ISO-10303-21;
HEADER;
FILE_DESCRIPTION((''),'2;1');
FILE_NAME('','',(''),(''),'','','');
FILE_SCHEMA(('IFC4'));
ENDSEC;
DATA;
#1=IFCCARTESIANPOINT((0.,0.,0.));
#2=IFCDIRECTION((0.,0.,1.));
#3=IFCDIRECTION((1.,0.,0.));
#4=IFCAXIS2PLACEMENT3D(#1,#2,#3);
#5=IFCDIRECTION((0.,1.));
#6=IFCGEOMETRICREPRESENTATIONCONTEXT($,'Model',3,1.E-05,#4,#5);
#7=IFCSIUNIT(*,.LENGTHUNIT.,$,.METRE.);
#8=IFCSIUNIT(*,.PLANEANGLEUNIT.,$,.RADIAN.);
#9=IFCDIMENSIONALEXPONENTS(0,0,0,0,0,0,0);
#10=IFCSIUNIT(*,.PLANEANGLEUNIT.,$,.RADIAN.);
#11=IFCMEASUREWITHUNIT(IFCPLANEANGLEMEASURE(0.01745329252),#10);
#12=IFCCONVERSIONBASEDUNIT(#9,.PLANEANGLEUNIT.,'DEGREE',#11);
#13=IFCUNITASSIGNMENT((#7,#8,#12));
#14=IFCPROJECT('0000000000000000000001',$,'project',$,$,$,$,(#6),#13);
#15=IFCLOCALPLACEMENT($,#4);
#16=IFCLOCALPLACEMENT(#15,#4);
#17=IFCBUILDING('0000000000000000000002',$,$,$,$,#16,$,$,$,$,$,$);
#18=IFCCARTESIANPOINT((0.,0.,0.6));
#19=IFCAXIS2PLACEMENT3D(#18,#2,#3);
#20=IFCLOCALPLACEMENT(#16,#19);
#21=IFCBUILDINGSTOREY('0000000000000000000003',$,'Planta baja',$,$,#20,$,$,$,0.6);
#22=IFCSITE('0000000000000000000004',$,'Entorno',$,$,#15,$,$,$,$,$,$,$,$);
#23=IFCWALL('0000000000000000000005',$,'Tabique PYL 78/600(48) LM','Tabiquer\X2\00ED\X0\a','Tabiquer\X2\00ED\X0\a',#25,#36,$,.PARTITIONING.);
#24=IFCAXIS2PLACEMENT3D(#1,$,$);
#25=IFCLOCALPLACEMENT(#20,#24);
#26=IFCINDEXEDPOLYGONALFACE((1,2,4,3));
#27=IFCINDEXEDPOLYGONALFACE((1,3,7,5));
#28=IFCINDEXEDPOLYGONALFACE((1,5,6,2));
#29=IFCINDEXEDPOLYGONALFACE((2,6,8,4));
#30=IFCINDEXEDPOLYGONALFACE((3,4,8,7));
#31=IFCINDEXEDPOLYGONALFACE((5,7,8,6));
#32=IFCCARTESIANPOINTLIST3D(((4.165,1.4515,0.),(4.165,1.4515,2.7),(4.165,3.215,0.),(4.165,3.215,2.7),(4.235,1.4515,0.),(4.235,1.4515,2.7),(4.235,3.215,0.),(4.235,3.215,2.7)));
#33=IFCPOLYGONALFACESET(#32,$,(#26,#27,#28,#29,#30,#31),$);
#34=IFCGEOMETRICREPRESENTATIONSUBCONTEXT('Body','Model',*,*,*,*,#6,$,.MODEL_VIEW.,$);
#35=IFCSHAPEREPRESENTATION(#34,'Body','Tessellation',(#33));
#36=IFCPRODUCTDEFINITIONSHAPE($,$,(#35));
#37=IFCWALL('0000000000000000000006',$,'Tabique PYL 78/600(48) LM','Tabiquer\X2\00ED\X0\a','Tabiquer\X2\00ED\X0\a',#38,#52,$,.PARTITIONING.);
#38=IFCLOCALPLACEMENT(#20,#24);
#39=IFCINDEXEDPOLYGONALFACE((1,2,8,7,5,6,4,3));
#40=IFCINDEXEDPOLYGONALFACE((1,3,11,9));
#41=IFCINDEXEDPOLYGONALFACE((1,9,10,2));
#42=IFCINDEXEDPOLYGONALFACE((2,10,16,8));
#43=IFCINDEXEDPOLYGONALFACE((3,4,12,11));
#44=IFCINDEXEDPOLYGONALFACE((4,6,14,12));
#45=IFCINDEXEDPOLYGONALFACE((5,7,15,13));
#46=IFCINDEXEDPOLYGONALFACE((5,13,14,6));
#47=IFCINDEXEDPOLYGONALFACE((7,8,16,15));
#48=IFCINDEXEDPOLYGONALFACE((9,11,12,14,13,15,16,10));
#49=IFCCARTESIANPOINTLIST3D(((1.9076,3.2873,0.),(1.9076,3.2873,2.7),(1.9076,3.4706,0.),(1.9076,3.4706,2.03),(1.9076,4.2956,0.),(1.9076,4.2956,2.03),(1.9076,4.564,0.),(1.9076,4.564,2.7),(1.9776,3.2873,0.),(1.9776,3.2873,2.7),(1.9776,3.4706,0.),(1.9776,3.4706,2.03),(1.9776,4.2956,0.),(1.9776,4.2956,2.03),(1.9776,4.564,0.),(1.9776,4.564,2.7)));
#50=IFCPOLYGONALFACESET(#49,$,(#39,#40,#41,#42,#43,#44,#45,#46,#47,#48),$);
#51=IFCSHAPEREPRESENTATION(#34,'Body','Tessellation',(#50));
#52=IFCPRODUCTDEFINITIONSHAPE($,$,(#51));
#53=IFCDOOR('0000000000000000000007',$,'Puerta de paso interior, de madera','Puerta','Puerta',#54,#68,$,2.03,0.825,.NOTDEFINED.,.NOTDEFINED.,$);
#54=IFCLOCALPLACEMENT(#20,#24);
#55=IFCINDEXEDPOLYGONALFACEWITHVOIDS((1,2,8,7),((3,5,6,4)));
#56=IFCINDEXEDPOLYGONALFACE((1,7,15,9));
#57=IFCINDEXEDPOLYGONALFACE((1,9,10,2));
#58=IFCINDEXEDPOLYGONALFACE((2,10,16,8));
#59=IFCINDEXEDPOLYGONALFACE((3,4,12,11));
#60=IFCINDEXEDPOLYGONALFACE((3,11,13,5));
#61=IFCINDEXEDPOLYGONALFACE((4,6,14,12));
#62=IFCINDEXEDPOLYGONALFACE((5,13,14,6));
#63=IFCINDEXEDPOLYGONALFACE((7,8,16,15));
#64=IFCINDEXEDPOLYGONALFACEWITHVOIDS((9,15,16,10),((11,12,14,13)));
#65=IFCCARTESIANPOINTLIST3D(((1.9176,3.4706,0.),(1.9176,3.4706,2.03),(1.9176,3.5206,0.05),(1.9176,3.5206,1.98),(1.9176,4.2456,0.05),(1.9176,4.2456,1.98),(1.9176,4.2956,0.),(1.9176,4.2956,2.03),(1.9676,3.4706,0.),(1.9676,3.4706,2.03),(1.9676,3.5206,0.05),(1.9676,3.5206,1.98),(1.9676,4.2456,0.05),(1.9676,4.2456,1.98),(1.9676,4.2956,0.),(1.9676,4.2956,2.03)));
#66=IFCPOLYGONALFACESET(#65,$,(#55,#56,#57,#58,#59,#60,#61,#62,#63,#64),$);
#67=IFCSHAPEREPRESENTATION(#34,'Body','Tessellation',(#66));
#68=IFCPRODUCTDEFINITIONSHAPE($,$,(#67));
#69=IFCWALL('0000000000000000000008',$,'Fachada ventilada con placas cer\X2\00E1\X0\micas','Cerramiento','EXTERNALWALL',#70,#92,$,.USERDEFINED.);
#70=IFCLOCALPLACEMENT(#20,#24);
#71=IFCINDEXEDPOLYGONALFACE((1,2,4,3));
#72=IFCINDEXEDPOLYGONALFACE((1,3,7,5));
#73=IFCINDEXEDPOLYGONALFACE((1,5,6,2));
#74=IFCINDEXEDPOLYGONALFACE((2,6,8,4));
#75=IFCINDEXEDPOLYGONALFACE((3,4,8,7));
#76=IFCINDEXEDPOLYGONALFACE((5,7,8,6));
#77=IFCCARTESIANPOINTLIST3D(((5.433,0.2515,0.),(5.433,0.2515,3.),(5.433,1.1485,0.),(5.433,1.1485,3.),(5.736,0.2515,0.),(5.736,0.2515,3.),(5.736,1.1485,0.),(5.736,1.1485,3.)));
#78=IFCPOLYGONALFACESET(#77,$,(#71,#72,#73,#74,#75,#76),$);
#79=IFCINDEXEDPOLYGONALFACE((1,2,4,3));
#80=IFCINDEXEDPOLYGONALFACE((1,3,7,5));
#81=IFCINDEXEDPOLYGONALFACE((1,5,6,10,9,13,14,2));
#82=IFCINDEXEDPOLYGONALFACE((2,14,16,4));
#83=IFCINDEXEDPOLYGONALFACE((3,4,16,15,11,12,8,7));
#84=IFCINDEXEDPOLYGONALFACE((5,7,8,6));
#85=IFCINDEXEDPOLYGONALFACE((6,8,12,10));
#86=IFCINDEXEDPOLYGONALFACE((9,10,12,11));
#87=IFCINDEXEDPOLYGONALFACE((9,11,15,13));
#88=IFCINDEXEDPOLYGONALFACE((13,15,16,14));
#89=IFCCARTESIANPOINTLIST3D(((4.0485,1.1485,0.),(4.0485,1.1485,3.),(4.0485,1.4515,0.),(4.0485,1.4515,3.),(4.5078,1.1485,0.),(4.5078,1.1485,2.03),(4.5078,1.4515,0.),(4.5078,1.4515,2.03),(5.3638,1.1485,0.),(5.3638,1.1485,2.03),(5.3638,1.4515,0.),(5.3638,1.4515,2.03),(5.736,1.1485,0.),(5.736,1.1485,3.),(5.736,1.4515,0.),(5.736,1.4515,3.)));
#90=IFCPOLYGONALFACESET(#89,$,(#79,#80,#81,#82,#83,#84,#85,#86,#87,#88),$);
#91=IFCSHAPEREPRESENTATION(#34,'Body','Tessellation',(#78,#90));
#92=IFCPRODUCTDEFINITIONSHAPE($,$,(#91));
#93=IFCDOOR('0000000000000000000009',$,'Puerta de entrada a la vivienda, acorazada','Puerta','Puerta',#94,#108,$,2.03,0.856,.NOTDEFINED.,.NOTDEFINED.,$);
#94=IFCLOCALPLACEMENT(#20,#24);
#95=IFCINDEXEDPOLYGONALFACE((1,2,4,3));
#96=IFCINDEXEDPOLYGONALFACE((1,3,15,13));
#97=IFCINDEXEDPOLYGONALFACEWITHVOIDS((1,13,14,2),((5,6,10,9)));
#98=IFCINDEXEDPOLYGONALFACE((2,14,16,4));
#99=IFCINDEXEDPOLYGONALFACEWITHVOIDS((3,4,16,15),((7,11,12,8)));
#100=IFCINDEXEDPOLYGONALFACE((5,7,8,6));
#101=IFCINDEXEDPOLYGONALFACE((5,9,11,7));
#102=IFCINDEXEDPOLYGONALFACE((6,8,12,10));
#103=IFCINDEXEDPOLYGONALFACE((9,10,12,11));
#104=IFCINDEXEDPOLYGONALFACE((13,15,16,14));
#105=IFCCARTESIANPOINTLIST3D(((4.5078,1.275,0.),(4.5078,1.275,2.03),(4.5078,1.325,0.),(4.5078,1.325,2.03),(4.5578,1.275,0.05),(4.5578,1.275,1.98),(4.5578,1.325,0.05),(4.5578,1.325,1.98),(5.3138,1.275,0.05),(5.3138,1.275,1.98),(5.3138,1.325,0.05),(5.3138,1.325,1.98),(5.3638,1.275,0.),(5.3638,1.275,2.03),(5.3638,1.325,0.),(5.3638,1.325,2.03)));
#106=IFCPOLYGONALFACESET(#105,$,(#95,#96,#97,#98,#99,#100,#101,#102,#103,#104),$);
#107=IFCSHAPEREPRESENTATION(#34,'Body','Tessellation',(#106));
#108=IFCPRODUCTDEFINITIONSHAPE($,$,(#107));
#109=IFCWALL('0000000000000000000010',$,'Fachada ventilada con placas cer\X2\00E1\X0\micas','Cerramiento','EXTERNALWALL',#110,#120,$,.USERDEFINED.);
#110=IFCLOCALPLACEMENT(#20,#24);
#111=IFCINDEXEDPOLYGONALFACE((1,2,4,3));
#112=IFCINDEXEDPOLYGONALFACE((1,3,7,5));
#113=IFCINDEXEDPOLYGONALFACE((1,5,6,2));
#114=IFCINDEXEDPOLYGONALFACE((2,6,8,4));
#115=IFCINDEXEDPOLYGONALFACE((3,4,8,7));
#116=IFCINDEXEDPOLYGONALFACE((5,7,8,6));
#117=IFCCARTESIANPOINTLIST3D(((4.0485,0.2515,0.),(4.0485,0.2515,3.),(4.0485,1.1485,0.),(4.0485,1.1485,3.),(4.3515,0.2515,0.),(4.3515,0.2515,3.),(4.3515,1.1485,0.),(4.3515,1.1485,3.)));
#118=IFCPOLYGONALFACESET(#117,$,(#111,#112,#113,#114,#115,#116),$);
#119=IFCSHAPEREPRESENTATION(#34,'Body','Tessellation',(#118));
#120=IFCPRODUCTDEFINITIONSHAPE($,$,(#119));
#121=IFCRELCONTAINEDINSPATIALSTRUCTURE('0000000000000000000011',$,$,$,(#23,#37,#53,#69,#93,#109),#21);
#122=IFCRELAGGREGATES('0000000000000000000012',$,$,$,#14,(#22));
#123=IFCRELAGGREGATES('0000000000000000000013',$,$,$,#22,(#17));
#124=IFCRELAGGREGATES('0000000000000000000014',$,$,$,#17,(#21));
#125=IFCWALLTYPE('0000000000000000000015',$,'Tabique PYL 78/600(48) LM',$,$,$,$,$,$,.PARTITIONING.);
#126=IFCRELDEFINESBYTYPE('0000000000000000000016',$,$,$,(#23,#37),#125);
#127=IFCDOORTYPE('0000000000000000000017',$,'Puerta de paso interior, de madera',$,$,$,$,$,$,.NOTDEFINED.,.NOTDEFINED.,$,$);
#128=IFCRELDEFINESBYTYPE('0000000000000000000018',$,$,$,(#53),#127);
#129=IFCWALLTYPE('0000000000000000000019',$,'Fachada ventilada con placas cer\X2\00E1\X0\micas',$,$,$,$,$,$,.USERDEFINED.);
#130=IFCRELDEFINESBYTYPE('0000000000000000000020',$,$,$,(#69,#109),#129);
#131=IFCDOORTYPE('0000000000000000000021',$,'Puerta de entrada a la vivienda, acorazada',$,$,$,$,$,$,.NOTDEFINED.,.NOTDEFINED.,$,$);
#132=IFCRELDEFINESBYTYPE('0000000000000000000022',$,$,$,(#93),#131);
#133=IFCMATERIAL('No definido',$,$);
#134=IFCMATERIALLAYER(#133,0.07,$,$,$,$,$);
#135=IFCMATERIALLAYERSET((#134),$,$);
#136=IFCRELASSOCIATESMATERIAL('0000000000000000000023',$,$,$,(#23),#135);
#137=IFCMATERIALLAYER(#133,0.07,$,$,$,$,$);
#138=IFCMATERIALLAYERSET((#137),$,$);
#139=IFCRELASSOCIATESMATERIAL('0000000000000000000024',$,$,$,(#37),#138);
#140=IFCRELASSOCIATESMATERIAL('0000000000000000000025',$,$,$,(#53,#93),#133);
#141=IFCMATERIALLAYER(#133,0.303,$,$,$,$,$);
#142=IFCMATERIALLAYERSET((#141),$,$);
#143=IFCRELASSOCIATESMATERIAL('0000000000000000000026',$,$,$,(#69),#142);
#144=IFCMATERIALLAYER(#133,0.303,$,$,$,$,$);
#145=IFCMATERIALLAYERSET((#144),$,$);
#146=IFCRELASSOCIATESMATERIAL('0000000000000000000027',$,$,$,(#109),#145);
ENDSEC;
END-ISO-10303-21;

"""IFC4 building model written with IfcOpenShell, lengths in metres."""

from ifc_helpers import new_model, entity, si_unit, converted_unit, direction, frame, origin_with_axes, origin_2d_with_axis, place, context, subcontext, project, spatial, rectangle, hollow_rectangle, extrude, shape, material, layer, layer_set, layer_usage, type_object, element, fill, save


model = new_model("IFC4")

# Units and contexts
model_context = context("Model", 3, precision=1e-05, world=origin_with_axes(), true_north=direction((0.0, 1.0)))
body_context = subcontext(model_context, "Body", "Model", "MODEL_VIEW")
footprint_context = subcontext(model_context, "FootPrint", "Model", "MODEL_VIEW")
ifc_project = project(units=[si_unit("LENGTHUNIT", "METRE"), si_unit("PLANEANGLEUNIT", "RADIAN"), converted_unit("PLANEANGLEUNIT", "DEGREE", entity("IfcPlaneAngleMeasure", 0.01745329252), si_unit("PLANEANGLEUNIT", "RADIAN"), dimensions=[0, 0, 0, 0, 0, 0, 0])], contexts=[model_context])

# Site, building, storey
site_placement = place(None, origin_with_axes())
site = spatial("IfcSite", under=ifc_project, at=site_placement, Name="Entorno")
building_placement = place(site_placement, origin_with_axes())
building = spatial("IfcBuilding", under=site, at=building_placement)
storey_placement = place(building_placement, frame((0.0, 0.0, 0.6), z_axis=(0.0, 0.0, 1.0), x_axis=(1.0, 0.0, 0.0)))
storey = spatial("IfcBuildingStorey", under=building, at=storey_placement, Name="Planta baja", Elevation=0.6)

# Wall
ifc_material_1 = material(Name="No definido")
ifc_layer_1 = layer(ifc_material_1, 0.07)
ifc_layer_set_1 = layer_set([ifc_layer_1])
ifc_layer_usage_1 = layer_usage(ifc_layer_set_1, "AXIS2", "POSITIVE", -0.035)
wall_type_1 = type_object("IfcWallType", Name="Tabique PYL 78/600(48) LM", PredefinedType="PARTITIONING")
wall_1_placement = place(storey_placement, frame((4.2, 1.3, 0.0), z_axis=(0.0, 0.0, 1.0), x_axis=(0.0, 1.0, 0.0)))
cartesian_point_1 = entity("IfcCartesianPoint", [-0.8817, -1.35])
cartesian_point_2 = entity("IfcCartesianPoint", [-0.8817, -1.35])
element("IfcWall", 1, at=wall_1_placement, inside=storey, type_object=wall_type_1, material=ifc_layer_usage_1, Name="Tabique PYL 78/600(48) LM", Description="Tabiquería", ObjectType="Tabiquería", PredefinedType="PARTITIONING", context=body_context, shape_type="SolidModel", body=[
    entity("IfcExtrudedAreaSolidTapered", entity("IfcArbitraryClosedProfileDef", "AREA", None, entity("IfcPolyline", [cartesian_point_1, entity("IfcCartesianPoint", [0.8817, -1.35]), entity("IfcCartesianPoint", [0.8817, 1.35]), entity("IfcCartesianPoint", [-0.8817, 1.35]), cartesian_point_1])), entity("IfcAxis2Placement3D", entity("IfcCartesianPoint", [1.0332, 0.035, 1.35]), entity("IfcDirection", [0.0, -1.0, 0.0]), entity("IfcDirection", [1.0, 0.0, 0.0])), entity("IfcDirection", [0.0, 0.0, 1.0]), 0.07, entity("IfcArbitraryClosedProfileDef", "AREA", None, entity("IfcPolyline", [cartesian_point_2, entity("IfcCartesianPoint", [0.8817, -1.35]), entity("IfcCartesianPoint", [0.8817, 1.35]), entity("IfcCartesianPoint", [-0.8817, 1.35]), cartesian_point_2]))),
])

# Walls, openings, doors
ifc_layer_2 = layer(ifc_material_1, 0.07)
ifc_layer_set_2 = layer_set([ifc_layer_2])
ifc_layer_usage_2 = layer_usage(ifc_layer_set_2, "AXIS2", "POSITIVE", -0.035)
wall_2_placement = place(storey_placement, frame((1.9426, 3.25, 0.0), z_axis=(0.0, 0.0, 1.0), x_axis=(0.0, 1.0, 0.0)))
cartesian_point_3 = entity("IfcCartesianPoint", [-0.6383, -1.35])
cartesian_point_4 = entity("IfcCartesianPoint", [-0.6383, -1.35])
wall_2 = element("IfcWall", 2, at=wall_2_placement, inside=storey, type_object=wall_type_1, material=ifc_layer_usage_2, Name="Tabique PYL 78/600(48) LM", Description="Tabiquería", ObjectType="Tabiquería", PredefinedType="PARTITIONING", context=body_context, shape_type="SolidModel", body=[
    entity("IfcExtrudedAreaSolidTapered", entity("IfcArbitraryClosedProfileDef", "AREA", None, entity("IfcPolyline", [cartesian_point_3, entity("IfcCartesianPoint", [0.6383, -1.35]), entity("IfcCartesianPoint", [0.6383, 1.35]), entity("IfcCartesianPoint", [-0.6383, 1.35]), cartesian_point_3])), entity("IfcAxis2Placement3D", entity("IfcCartesianPoint", [0.6757, 0.035, 1.35]), entity("IfcDirection", [0.0, -1.0, 0.0]), entity("IfcDirection", [1.0, 0.0, 0.0])), entity("IfcDirection", [0.0, 0.0, 1.0]), 0.07, entity("IfcArbitraryClosedProfileDef", "AREA", None, entity("IfcPolyline", [cartesian_point_4, entity("IfcCartesianPoint", [0.6383, -1.35]), entity("IfcCartesianPoint", [0.6383, 1.35]), entity("IfcCartesianPoint", [-0.6383, 1.35]), cartesian_point_4]))),
])
opening_1_placement = place(wall_2_placement, frame((0.6331, 0.0, 1.015), z_axis=(0.0, 0.0, 1.0), x_axis=(1.0, 0.0, 0.0)))
cartesian_point_5 = entity("IfcCartesianPoint", [-0.4125, -0.035])
opening_1 = element("IfcOpeningElement", 3, at=opening_1_placement, cuts=wall_2, ObjectType="No definido", PredefinedType="OPENING", shapes=[
    shape(body_context, "Body", "SweptSolid", [extrude(rectangle(XDim=2.03, YDim=0.825, at=origin_2d_with_axis()), frame((0.0, -0.035, 0.0), z_axis=(0.0, 1.0, 0.0), x_axis=(0.0, 0.0, 1.0)), (0.0, 0.0, 1.0), 0.07)]),
    shape(footprint_context, "FootPrint", "GeometricCurveSet", [entity("IfcGeometricCurveSet", [entity("IfcPolyline", [cartesian_point_5, entity("IfcCartesianPoint", [0.4125, -0.035]), entity("IfcCartesianPoint", [0.4125, 0.035]), entity("IfcCartesianPoint", [-0.4125, 0.035]), cartesian_point_5])])]),
])
door_type_1 = type_object("IfcDoorType", Name="Puerta de paso interior, de madera", OperationType="NOTDEFINED", PredefinedType="NOTDEFINED")
door_1_placement = place(opening_1_placement, origin_with_axes())
door_1 = element("IfcDoor", 4, at=door_1_placement, inside=storey, type_object=door_type_1, material=ifc_material_1, Name="Puerta de paso interior, de madera", Description="Puerta", ObjectType="Puerta", OperationType="NOTDEFINED", OverallHeight=2.03, OverallWidth=0.825, PredefinedType="NOTDEFINED", context=body_context, shape_type="SweptSolid", body=[
    extrude(hollow_rectangle(XDim=0.825, YDim=2.03, WallThickness=0.05, InnerFilletRadius=0.0, OuterFilletRadius=0.0, at=origin_2d_with_axis()), frame((0.0, 0.025, 0.0), z_axis=(0.0, -1.0, 0.0), x_axis=(1.0, 0.0, 0.0)), (0.0, 0.0, 1.0), 0.05),
])
fill(opening_1, door_1)
ifc_layer_3 = layer(ifc_material_1, 0.303)
ifc_layer_set_3 = layer_set([ifc_layer_3])
ifc_layer_usage_3 = layer_usage(ifc_layer_set_3, "AXIS2", "POSITIVE", -0.1515)
wall_type_2 = type_object("IfcWallType", Name="Fachada ventilada con placas cerámicas", PredefinedType="USERDEFINED")
wall_3_placement = place(storey_placement, frame((5.5845, 0.1, 0.0), z_axis=(0.0, 0.0, 1.0), x_axis=(0.0, 1.0, 0.0)))
cartesian_point_6 = entity("IfcCartesianPoint", [-0.4485, -1.5])
cartesian_point_7 = entity("IfcCartesianPoint", [-0.4485, -1.5])
cartesian_point_8 = entity("IfcCartesianPoint", [-0.8438, -1.5])
cartesian_point_9 = entity("IfcCartesianPoint", [-0.8438, -1.5])
wall_3 = element("IfcWall", 5, at=wall_3_placement, inside=storey, type_object=wall_type_2, material=ifc_layer_usage_3, Name="Fachada ventilada con placas cerámicas", Description="Cerramiento", ObjectType="EXTERNALWALL", PredefinedType="USERDEFINED", context=body_context, shape_type="SolidModel", body=[
    entity("IfcExtrudedAreaSolidTapered", entity("IfcArbitraryClosedProfileDef", "AREA", None, entity("IfcPolyline", [cartesian_point_6, entity("IfcCartesianPoint", [0.4485, -1.5]), entity("IfcCartesianPoint", [0.4485, 1.5]), entity("IfcCartesianPoint", [-0.4485, 1.5]), cartesian_point_6])), entity("IfcAxis2Placement3D", entity("IfcCartesianPoint", [0.6, 0.1515, 1.5]), entity("IfcDirection", [0.0, -1.0, 0.0]), entity("IfcDirection", [1.0, 0.0, 0.0])), entity("IfcDirection", [0.0, 0.0, 1.0]), 0.303, entity("IfcArbitraryClosedProfileDef", "AREA", None, entity("IfcPolyline", [cartesian_point_7, entity("IfcCartesianPoint", [0.4485, -1.5]), entity("IfcCartesianPoint", [0.4485, 1.5]), entity("IfcCartesianPoint", [-0.4485, 1.5]), cartesian_point_7]))),
    entity("IfcExtrudedAreaSolidTapered", entity("IfcArbitraryClosedProfileDef", "AREA", None, entity("IfcPolyline", [cartesian_point_8, entity("IfcCartesianPoint", [0.8438, -1.5]), entity("IfcCartesianPoint", [0.8438, 1.5]), entity("IfcCartesianPoint", [-0.8438, 1.5]), cartesian_point_8])), entity("IfcAxis2Placement3D", entity("IfcCartesianPoint", [1.0485, 0.6923, 1.5]), entity("IfcDirection", [1.0, 0.0, 0.0]), entity("IfcDirection", [0.0, 1.0, 0.0])), entity("IfcDirection", [0.0, 0.0, 1.0]), 0.303, entity("IfcArbitraryClosedProfileDef", "AREA", None, entity("IfcPolyline", [cartesian_point_9, entity("IfcCartesianPoint", [0.8438, -1.5]), entity("IfcCartesianPoint", [0.8438, 1.5]), entity("IfcCartesianPoint", [-0.8438, 1.5]), cartesian_point_9]))),
])
opening_2_placement = place(wall_3_placement, frame((1.2, 0.6487, 1.015), z_axis=(0.0, 0.0, 1.0), x_axis=(0.0, 1.0, 0.0)))
cartesian_point_10 = entity("IfcCartesianPoint", [-0.428, -0.1515])
opening_2 = element("IfcOpeningElement", 6, at=opening_2_placement, cuts=wall_3, ObjectType="No definido", PredefinedType="OPENING", shapes=[
    shape(body_context, "Body", "SweptSolid", [extrude(rectangle(XDim=2.03, YDim=0.856, at=origin_2d_with_axis()), frame((0.0, -0.1515, 0.0), z_axis=(0.0, 1.0, 0.0), x_axis=(0.0, 0.0, 1.0)), (0.0, 0.0, 1.0), 0.303)]),
    shape(footprint_context, "FootPrint", "GeometricCurveSet", [entity("IfcGeometricCurveSet", [entity("IfcPolyline", [cartesian_point_10, entity("IfcCartesianPoint", [0.428, -0.1515]), entity("IfcCartesianPoint", [0.428, 0.1515]), entity("IfcCartesianPoint", [-0.428, 0.1515]), cartesian_point_10])])]),
])
door_type_2 = type_object("IfcDoorType", Name="Puerta de entrada a la vivienda, acorazada", OperationType="NOTDEFINED", PredefinedType="NOTDEFINED")
door_2_placement = place(opening_2_placement, origin_with_axes())
door_2 = element("IfcDoor", 7, at=door_2_placement, inside=storey, type_object=door_type_2, material=ifc_material_1, Name="Puerta de entrada a la vivienda, acorazada", Description="Puerta", ObjectType="Puerta", OperationType="NOTDEFINED", OverallHeight=2.03, OverallWidth=0.856, PredefinedType="NOTDEFINED", context=body_context, shape_type="SweptSolid", body=[
    extrude(hollow_rectangle(XDim=0.856, YDim=2.03, WallThickness=0.05, InnerFilletRadius=0.0, OuterFilletRadius=0.0, at=origin_2d_with_axis()), frame((0.0, 0.025, 0.0), z_axis=(0.0, -1.0, 0.0), x_axis=(1.0, 0.0, 0.0)), (0.0, 0.0, 1.0), 0.05),
])
fill(opening_2, door_2)

# Wall
ifc_layer_4 = layer(ifc_material_1, 0.303)
ifc_layer_set_4 = layer_set([ifc_layer_4])
ifc_layer_usage_4 = layer_usage(ifc_layer_set_4, "AXIS2", "POSITIVE", -0.1515)
wall_4_placement = place(storey_placement, frame((4.2, 1.3, 0.0), z_axis=(0.0, 0.0, 1.0), x_axis=(0.0, -1.0, 0.0)))
cartesian_point_11 = entity("IfcCartesianPoint", [-0.4485, -1.5])
cartesian_point_12 = entity("IfcCartesianPoint", [-0.4485, -1.5])
element("IfcWall", 8, at=wall_4_placement, inside=storey, type_object=wall_type_2, material=ifc_layer_usage_4, Name="Fachada ventilada con placas cerámicas", Description="Cerramiento", ObjectType="EXTERNALWALL", PredefinedType="USERDEFINED", context=body_context, shape_type="SolidModel", body=[
    entity("IfcExtrudedAreaSolidTapered", entity("IfcArbitraryClosedProfileDef", "AREA", None, entity("IfcPolyline", [cartesian_point_11, entity("IfcCartesianPoint", [0.4485, -1.5]), entity("IfcCartesianPoint", [0.4485, 1.5]), entity("IfcCartesianPoint", [-0.4485, 1.5]), cartesian_point_11])), entity("IfcAxis2Placement3D", entity("IfcCartesianPoint", [0.6, 0.1515, 1.5]), entity("IfcDirection", [0.0, -1.0, 0.0]), entity("IfcDirection", [1.0, 0.0, 0.0])), entity("IfcDirection", [0.0, 0.0, 1.0]), 0.303, entity("IfcArbitraryClosedProfileDef", "AREA", None, entity("IfcPolyline", [cartesian_point_12, entity("IfcCartesianPoint", [0.4485, -1.5]), entity("IfcCartesianPoint", [0.4485, 1.5]), entity("IfcCartesianPoint", [-0.4485, 1.5]), cartesian_point_12]))),
])

save(model, "model.ifc")
